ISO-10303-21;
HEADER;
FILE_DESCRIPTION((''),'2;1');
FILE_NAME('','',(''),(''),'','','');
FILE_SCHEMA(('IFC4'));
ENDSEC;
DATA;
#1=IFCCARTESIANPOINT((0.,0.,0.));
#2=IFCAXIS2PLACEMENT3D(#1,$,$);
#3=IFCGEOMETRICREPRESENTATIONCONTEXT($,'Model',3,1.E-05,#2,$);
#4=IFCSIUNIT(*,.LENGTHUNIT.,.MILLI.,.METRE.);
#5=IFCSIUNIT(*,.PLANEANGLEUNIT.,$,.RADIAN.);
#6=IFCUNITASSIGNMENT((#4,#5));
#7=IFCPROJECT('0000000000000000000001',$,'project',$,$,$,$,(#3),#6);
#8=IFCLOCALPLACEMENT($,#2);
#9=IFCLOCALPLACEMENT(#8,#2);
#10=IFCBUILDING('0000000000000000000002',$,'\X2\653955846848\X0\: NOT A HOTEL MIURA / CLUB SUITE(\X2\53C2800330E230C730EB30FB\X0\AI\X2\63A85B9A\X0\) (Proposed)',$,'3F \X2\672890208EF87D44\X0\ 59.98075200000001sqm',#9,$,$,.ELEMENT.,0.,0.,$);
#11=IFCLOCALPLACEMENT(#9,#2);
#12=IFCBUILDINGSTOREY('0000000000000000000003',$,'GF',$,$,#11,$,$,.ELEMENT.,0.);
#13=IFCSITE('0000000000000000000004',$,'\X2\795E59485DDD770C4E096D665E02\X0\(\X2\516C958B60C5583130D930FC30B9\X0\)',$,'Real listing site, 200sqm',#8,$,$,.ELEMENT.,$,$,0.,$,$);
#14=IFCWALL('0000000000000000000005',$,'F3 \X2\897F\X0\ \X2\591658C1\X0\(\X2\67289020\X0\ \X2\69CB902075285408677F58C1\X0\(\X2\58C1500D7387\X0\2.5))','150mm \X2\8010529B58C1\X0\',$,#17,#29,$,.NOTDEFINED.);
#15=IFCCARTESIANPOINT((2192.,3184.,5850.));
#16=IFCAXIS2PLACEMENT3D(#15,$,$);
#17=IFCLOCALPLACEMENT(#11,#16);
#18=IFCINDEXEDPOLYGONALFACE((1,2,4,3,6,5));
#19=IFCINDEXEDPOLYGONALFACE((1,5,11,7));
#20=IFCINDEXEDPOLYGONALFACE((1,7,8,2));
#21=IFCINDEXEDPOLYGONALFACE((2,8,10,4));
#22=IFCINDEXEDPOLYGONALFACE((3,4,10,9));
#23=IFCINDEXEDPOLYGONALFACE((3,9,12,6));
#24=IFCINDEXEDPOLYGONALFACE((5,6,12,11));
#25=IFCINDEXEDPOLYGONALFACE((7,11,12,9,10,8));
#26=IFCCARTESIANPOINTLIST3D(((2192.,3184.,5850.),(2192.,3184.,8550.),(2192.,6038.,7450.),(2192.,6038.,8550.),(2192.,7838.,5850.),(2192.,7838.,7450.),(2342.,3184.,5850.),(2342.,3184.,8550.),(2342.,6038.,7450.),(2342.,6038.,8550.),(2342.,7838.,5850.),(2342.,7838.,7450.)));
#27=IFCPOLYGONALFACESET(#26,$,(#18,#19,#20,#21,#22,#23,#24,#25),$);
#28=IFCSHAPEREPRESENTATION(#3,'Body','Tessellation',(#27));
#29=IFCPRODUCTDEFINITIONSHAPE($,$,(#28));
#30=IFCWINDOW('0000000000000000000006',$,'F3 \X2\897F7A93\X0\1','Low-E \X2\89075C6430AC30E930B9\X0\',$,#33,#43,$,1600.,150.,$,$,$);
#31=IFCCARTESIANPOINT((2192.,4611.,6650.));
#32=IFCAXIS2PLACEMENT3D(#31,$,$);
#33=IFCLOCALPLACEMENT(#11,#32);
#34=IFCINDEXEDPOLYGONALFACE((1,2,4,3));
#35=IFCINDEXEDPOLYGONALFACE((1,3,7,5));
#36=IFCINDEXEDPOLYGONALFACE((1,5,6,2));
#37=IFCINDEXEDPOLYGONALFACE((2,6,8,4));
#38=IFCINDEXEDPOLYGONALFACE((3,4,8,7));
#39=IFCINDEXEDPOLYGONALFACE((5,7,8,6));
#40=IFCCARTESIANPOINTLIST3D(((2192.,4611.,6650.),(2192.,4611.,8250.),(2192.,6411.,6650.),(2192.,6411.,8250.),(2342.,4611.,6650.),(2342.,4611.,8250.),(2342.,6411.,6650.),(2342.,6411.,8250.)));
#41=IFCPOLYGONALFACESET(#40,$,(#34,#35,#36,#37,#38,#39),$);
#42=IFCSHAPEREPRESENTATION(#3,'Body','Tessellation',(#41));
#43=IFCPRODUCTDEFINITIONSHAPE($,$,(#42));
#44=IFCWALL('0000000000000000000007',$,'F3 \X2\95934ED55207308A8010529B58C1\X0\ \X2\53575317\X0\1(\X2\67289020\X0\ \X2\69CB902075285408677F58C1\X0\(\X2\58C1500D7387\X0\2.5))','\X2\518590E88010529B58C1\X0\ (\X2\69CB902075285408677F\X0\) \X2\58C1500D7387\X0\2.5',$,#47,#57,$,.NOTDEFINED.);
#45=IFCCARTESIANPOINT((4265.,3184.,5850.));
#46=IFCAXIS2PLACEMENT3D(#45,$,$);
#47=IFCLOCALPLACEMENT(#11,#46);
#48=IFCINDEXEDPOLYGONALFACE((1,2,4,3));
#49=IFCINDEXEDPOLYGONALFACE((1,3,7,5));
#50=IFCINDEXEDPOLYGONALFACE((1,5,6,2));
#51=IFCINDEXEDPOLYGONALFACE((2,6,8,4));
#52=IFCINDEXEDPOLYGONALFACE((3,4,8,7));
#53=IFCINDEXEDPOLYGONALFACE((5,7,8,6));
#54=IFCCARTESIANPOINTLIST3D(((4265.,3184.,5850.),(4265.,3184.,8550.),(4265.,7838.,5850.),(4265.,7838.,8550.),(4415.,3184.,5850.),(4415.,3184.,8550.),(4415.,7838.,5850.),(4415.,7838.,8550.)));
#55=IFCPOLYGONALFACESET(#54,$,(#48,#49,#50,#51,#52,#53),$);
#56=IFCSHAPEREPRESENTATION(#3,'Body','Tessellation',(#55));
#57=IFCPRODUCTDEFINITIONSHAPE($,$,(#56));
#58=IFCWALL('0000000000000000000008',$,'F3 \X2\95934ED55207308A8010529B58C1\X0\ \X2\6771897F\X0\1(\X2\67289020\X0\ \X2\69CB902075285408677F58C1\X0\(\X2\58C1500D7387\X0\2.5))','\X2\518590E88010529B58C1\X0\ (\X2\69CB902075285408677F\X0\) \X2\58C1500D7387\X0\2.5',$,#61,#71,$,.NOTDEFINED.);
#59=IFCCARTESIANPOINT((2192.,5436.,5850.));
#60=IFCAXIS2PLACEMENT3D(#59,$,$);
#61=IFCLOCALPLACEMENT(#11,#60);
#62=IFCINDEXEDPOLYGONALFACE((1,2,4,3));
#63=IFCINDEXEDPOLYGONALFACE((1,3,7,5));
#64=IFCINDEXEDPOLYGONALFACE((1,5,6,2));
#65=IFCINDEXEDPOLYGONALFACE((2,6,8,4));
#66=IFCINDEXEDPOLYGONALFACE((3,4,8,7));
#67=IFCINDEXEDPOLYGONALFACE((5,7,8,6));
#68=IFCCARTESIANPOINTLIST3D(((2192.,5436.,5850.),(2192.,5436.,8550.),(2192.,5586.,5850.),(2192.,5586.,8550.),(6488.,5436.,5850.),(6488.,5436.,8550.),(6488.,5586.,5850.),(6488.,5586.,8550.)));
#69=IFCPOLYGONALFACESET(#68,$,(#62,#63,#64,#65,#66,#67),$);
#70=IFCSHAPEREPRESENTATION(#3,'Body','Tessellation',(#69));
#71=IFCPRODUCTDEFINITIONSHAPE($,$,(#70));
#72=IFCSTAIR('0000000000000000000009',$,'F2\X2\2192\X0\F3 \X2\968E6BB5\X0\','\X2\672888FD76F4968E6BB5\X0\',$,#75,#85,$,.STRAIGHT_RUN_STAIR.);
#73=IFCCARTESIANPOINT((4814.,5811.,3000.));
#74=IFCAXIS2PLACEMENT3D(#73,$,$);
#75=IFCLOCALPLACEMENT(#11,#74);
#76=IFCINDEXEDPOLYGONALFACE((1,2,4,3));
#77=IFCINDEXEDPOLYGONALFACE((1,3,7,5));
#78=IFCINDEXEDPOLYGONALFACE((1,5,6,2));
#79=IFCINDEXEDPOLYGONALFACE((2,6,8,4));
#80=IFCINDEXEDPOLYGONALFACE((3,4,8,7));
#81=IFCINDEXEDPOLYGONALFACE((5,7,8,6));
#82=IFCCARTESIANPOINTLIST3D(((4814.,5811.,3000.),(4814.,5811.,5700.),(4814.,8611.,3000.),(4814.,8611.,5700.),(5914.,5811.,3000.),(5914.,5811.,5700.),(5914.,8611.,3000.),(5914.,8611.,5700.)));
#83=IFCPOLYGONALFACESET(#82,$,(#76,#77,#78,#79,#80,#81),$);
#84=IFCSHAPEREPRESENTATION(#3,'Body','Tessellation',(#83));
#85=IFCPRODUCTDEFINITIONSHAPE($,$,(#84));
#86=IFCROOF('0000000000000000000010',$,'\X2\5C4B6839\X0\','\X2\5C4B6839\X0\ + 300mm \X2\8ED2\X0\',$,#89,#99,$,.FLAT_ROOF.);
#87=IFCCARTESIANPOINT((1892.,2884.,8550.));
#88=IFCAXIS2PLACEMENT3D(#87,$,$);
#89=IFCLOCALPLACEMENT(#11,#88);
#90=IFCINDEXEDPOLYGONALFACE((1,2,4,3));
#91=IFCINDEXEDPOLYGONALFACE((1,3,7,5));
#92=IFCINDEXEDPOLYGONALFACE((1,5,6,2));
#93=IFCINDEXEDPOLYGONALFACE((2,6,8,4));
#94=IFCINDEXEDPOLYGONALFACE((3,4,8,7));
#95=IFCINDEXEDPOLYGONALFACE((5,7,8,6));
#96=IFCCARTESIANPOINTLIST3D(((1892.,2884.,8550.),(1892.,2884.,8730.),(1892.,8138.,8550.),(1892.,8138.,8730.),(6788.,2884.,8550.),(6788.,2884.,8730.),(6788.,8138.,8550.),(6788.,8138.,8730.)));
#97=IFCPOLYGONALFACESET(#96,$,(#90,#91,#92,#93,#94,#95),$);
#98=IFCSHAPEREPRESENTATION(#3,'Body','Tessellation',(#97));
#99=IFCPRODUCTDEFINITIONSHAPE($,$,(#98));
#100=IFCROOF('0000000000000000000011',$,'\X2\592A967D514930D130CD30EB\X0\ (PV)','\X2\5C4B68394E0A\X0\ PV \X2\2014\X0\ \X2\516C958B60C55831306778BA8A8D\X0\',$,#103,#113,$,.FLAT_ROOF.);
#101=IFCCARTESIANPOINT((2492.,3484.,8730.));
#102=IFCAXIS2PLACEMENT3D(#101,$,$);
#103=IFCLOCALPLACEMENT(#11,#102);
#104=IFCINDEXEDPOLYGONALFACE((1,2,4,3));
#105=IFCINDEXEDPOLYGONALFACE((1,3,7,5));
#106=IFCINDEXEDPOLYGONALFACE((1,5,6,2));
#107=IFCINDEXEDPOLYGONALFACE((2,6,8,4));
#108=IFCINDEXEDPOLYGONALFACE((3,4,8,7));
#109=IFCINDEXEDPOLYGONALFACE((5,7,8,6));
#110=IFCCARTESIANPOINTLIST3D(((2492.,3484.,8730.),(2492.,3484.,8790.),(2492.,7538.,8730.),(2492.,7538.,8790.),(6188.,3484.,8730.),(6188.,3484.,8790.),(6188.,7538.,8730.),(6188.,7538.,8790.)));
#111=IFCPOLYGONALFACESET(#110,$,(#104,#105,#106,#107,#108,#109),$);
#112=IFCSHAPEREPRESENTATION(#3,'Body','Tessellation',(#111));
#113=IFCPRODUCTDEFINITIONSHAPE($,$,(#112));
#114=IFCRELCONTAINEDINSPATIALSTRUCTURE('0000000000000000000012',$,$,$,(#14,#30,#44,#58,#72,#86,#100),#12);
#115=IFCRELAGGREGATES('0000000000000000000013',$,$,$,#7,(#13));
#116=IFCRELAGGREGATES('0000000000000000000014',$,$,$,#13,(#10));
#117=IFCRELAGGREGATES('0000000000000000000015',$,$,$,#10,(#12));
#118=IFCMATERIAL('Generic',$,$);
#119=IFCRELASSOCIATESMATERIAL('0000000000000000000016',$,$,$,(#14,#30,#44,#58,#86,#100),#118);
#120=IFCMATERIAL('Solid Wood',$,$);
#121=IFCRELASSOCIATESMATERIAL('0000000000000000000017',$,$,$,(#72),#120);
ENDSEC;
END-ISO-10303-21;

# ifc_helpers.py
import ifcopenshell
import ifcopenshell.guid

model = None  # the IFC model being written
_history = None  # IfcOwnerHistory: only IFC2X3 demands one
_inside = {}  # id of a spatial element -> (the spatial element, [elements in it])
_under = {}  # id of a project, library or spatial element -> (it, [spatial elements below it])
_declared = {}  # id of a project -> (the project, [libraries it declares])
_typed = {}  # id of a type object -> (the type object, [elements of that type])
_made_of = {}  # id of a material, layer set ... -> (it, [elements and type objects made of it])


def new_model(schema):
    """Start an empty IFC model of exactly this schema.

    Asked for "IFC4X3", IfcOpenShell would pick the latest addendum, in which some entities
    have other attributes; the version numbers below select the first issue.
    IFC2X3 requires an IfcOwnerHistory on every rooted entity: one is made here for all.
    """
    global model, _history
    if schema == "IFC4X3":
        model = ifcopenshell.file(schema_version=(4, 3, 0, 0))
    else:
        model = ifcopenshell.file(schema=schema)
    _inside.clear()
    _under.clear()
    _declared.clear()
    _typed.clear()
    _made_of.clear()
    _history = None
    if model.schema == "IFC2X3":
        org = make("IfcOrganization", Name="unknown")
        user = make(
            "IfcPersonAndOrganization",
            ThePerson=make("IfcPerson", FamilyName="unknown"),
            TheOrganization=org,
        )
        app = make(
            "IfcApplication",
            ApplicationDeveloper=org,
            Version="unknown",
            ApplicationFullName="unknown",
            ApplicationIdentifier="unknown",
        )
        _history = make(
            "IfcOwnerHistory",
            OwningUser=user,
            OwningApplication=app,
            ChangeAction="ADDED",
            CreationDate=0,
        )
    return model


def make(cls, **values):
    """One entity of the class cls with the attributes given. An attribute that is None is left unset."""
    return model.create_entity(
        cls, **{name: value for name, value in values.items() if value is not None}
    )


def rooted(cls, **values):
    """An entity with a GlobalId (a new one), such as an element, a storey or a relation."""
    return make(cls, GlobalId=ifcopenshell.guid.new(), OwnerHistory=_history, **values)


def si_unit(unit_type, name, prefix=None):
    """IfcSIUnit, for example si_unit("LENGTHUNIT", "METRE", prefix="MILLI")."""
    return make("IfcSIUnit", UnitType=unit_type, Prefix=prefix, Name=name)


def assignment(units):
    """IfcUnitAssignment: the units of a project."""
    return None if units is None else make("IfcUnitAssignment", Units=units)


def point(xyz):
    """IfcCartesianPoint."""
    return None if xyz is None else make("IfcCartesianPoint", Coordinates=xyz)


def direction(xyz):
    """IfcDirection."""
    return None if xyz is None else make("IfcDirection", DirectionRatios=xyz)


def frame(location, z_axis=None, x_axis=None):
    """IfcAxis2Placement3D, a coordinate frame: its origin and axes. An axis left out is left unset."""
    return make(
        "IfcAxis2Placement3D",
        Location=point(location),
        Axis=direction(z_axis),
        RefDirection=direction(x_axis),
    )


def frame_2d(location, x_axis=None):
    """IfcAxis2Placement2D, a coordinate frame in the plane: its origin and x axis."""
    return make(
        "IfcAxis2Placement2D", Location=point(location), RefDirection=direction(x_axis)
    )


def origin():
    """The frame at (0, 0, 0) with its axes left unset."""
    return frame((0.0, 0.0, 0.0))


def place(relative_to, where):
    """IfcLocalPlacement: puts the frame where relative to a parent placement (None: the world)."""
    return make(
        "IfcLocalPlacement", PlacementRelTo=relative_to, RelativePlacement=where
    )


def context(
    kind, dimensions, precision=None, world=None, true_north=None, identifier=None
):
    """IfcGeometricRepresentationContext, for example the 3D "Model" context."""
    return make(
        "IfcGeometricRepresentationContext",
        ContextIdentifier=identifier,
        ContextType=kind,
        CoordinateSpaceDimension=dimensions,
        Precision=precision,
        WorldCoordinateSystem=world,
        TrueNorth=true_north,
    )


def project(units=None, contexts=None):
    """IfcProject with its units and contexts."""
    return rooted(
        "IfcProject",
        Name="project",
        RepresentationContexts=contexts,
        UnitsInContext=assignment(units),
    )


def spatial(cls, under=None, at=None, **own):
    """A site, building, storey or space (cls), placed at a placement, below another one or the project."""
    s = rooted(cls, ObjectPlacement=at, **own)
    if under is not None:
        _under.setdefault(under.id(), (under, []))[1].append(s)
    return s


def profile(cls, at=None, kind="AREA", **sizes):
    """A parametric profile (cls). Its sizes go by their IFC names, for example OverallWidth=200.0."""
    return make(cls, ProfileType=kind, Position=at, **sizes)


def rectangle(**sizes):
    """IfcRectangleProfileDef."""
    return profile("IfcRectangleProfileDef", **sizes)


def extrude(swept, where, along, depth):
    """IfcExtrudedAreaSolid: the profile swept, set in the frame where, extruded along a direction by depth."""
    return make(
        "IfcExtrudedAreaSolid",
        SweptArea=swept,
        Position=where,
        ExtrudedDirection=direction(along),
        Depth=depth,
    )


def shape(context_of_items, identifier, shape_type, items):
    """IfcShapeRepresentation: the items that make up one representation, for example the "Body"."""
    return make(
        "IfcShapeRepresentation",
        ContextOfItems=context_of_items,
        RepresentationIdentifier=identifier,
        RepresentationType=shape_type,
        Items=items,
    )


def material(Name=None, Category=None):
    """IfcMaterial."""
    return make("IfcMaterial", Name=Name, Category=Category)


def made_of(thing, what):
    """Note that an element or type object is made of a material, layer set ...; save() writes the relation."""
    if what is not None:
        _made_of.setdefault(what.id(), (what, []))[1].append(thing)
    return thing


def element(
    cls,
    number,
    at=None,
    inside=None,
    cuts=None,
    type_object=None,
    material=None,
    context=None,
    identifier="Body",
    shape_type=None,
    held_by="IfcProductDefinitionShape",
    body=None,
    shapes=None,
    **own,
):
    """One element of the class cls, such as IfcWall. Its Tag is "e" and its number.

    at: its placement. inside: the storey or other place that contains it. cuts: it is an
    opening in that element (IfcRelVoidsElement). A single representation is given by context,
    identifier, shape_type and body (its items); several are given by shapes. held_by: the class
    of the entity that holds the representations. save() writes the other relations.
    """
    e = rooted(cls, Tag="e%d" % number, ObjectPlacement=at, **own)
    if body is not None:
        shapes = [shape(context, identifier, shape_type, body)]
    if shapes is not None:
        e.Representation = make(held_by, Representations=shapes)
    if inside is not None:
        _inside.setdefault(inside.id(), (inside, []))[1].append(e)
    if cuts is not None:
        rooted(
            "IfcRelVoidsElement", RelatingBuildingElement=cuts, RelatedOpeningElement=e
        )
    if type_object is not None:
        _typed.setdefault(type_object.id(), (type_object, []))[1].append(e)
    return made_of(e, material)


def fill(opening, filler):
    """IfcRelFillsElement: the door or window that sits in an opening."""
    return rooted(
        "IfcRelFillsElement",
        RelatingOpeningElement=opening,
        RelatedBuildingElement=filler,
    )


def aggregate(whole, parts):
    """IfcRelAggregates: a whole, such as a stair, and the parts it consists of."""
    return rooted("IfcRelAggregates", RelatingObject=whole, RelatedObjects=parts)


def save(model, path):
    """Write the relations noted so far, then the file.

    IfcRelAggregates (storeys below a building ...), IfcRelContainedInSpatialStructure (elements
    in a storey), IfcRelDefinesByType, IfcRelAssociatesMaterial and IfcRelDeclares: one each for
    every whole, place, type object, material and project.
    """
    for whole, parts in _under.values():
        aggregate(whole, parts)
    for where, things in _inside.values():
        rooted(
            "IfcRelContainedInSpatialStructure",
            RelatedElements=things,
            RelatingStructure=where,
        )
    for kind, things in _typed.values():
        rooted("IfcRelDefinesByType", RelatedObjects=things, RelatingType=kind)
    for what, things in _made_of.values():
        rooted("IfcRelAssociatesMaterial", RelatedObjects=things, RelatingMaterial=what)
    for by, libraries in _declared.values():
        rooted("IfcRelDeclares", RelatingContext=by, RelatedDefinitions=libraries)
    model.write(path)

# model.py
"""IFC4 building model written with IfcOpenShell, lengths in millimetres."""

from ifc_helpers import new_model, si_unit, frame, frame_2d, origin, place, context, project, spatial, rectangle, extrude, material, element, fill, save


model = new_model("IFC4")

# Units and contexts
model_context = context("Model", 3, precision=1e-05, world=origin())
ifc_project = project(units=[si_unit("LENGTHUNIT", "METRE", prefix="MILLI"), si_unit("PLANEANGLEUNIT", "RADIAN")], contexts=[model_context])

# Site, building, storey
site_placement = place(None, origin())
site = spatial("IfcSite", under=ifc_project, at=site_placement, Name="神奈川県三浦市(公開情報ベース)", ObjectType="Real listing site, 200sqm", CompositionType="ELEMENT", RefElevation=0.0)
building_placement = place(site_placement, origin())
building = spatial("IfcBuilding", under=site, at=building_placement, Name="改善案: NOT A HOTEL MIURA / CLUB SUITE(参考モデル・AI推定) (Proposed)", ObjectType="3F 木造軸組 59.98075200000001sqm", CompositionType="ELEMENT", ElevationOfRefHeight=0.0, ElevationOfTerrain=0.0)
storey_placement = place(building_placement, origin())
storey = spatial("IfcBuildingStorey", under=building, at=storey_placement, Name="GF", CompositionType="ELEMENT", Elevation=0.0)

# Shared definitions
ifc_material_1 = material(Name="Generic")

# Wall, opening, window
wall_1_placement = place(storey_placement, frame((2192.0, 3184.0, 5850.0)))
wall_1 = element("IfcWall", 1, at=wall_1_placement, inside=storey, material=ifc_material_1, Name="F3 西 外壁(木造 構造用合板壁(壁倍率2.5))", Description="150mm 耐力壁", PredefinedType="NOTDEFINED", context=model_context, shape_type="SweptSolid", body=[
    extrude(rectangle(XDim=150.0, YDim=4654.0, at=frame_2d((75.0, 2327.0))), frame((2192.0, 3184.0, 5850.0)), (0.0, 0.0, 1.0), 2700.0),
])
opening_1_placement = place(storey_placement, frame((2192.0, 4611.0, 6650.0)))
opening_1 = element("IfcOpeningElement", 2, at=opening_1_placement, cuts=wall_1, PredefinedType="NOTDEFINED", context=model_context, shape_type="SweptSolid", body=[
    extrude(rectangle(XDim=150.0, YDim=1800.0, at=frame_2d((75.0, 900.0))), frame((2192.0, 4611.0, 6650.0)), (0.0, 0.0, 1.0), 1600.0),
])
window_1_placement = place(storey_placement, frame((2192.0, 4611.0, 6650.0)))
window_1 = element("IfcWindow", 3, at=window_1_placement, inside=storey, material=ifc_material_1, Name="F3 西窓1", Description="Low-E 複層ガラス", OverallHeight=1600.0, OverallWidth=150.0, context=model_context, shape_type="SweptSolid", body=[
    extrude(rectangle(XDim=150.0, YDim=1800.0, at=frame_2d((75.0, 900.0))), frame((2192.0, 4611.0, 6650.0)), (0.0, 0.0, 1.0), 1600.0),
])
fill(opening_1, window_1)

# Walls
wall_2_placement = place(storey_placement, frame((4265.0, 3184.0, 5850.0)))
element("IfcWall", 4, at=wall_2_placement, inside=storey, material=ifc_material_1, Name="F3 間仕切り耐力壁 南北1(木造 構造用合板壁(壁倍率2.5))", Description="内部耐力壁 (構造用合板) 壁倍率2.5", PredefinedType="NOTDEFINED", context=model_context, shape_type="SweptSolid", body=[
    extrude(rectangle(XDim=150.0, YDim=4654.0, at=frame_2d((75.0, 2327.0))), frame((4265.0, 3184.0, 5850.0)), (0.0, 0.0, 1.0), 2700.0),
])
wall_3_placement = place(storey_placement, frame((2192.0, 5436.0, 5850.0)))
element("IfcWall", 5, at=wall_3_placement, inside=storey, material=ifc_material_1, Name="F3 間仕切り耐力壁 東西1(木造 構造用合板壁(壁倍率2.5))", Description="内部耐力壁 (構造用合板) 壁倍率2.5", PredefinedType="NOTDEFINED", context=model_context, shape_type="SweptSolid", body=[
    extrude(rectangle(XDim=4296.0, YDim=150.0, at=frame_2d((2148.0, 75.0))), frame((2192.0, 5436.0, 5850.0)), (0.0, 0.0, 1.0), 2700.0),
])

# Stair
ifc_material_2 = material(Name="Solid Wood")
stair_placement = place(storey_placement, frame((4814.0, 5811.0, 3000.0)))
element("IfcStair", 6, at=stair_placement, inside=storey, material=ifc_material_2, Name="F2→F3 階段", Description="木製直階段", PredefinedType="STRAIGHT_RUN_STAIR", context=model_context, shape_type="SweptSolid", body=[
    extrude(rectangle(XDim=1100.0, YDim=2800.0, at=frame_2d((550.0, 1400.0))), frame((4814.0, 5811.0, 3000.0)), (0.0, 0.0, 1.0), 2700.0),
])

# Roofs
roof_1_placement = place(storey_placement, frame((1892.0, 2884.0, 8550.0)))
element("IfcRoof", 7, at=roof_1_placement, inside=storey, material=ifc_material_1, Name="屋根", Description="屋根 + 300mm 軒", PredefinedType="FLAT_ROOF", context=model_context, shape_type="SweptSolid", body=[
    extrude(rectangle(XDim=4896.0, YDim=5254.0, at=frame_2d((2448.0, 2627.0))), frame((1892.0, 2884.0, 8550.0)), (0.0, 0.0, 1.0), 180.0),
])
roof_2_placement = place(storey_placement, frame((2492.0, 3484.0, 8730.0)))
element("IfcRoof", 8, at=roof_2_placement, inside=storey, material=ifc_material_1, Name="太陽光パネル (PV)", Description="屋根上 PV — 公開情報で確認", PredefinedType="FLAT_ROOF", context=model_context, shape_type="SweptSolid", body=[
    extrude(rectangle(XDim=3696.0, YDim=4054.0, at=frame_2d((1848.0, 2027.0))), frame((2492.0, 3484.0, 8730.0)), (0.0, 0.0, 1.0), 60.0),
])

save(model, "model.ifc")
